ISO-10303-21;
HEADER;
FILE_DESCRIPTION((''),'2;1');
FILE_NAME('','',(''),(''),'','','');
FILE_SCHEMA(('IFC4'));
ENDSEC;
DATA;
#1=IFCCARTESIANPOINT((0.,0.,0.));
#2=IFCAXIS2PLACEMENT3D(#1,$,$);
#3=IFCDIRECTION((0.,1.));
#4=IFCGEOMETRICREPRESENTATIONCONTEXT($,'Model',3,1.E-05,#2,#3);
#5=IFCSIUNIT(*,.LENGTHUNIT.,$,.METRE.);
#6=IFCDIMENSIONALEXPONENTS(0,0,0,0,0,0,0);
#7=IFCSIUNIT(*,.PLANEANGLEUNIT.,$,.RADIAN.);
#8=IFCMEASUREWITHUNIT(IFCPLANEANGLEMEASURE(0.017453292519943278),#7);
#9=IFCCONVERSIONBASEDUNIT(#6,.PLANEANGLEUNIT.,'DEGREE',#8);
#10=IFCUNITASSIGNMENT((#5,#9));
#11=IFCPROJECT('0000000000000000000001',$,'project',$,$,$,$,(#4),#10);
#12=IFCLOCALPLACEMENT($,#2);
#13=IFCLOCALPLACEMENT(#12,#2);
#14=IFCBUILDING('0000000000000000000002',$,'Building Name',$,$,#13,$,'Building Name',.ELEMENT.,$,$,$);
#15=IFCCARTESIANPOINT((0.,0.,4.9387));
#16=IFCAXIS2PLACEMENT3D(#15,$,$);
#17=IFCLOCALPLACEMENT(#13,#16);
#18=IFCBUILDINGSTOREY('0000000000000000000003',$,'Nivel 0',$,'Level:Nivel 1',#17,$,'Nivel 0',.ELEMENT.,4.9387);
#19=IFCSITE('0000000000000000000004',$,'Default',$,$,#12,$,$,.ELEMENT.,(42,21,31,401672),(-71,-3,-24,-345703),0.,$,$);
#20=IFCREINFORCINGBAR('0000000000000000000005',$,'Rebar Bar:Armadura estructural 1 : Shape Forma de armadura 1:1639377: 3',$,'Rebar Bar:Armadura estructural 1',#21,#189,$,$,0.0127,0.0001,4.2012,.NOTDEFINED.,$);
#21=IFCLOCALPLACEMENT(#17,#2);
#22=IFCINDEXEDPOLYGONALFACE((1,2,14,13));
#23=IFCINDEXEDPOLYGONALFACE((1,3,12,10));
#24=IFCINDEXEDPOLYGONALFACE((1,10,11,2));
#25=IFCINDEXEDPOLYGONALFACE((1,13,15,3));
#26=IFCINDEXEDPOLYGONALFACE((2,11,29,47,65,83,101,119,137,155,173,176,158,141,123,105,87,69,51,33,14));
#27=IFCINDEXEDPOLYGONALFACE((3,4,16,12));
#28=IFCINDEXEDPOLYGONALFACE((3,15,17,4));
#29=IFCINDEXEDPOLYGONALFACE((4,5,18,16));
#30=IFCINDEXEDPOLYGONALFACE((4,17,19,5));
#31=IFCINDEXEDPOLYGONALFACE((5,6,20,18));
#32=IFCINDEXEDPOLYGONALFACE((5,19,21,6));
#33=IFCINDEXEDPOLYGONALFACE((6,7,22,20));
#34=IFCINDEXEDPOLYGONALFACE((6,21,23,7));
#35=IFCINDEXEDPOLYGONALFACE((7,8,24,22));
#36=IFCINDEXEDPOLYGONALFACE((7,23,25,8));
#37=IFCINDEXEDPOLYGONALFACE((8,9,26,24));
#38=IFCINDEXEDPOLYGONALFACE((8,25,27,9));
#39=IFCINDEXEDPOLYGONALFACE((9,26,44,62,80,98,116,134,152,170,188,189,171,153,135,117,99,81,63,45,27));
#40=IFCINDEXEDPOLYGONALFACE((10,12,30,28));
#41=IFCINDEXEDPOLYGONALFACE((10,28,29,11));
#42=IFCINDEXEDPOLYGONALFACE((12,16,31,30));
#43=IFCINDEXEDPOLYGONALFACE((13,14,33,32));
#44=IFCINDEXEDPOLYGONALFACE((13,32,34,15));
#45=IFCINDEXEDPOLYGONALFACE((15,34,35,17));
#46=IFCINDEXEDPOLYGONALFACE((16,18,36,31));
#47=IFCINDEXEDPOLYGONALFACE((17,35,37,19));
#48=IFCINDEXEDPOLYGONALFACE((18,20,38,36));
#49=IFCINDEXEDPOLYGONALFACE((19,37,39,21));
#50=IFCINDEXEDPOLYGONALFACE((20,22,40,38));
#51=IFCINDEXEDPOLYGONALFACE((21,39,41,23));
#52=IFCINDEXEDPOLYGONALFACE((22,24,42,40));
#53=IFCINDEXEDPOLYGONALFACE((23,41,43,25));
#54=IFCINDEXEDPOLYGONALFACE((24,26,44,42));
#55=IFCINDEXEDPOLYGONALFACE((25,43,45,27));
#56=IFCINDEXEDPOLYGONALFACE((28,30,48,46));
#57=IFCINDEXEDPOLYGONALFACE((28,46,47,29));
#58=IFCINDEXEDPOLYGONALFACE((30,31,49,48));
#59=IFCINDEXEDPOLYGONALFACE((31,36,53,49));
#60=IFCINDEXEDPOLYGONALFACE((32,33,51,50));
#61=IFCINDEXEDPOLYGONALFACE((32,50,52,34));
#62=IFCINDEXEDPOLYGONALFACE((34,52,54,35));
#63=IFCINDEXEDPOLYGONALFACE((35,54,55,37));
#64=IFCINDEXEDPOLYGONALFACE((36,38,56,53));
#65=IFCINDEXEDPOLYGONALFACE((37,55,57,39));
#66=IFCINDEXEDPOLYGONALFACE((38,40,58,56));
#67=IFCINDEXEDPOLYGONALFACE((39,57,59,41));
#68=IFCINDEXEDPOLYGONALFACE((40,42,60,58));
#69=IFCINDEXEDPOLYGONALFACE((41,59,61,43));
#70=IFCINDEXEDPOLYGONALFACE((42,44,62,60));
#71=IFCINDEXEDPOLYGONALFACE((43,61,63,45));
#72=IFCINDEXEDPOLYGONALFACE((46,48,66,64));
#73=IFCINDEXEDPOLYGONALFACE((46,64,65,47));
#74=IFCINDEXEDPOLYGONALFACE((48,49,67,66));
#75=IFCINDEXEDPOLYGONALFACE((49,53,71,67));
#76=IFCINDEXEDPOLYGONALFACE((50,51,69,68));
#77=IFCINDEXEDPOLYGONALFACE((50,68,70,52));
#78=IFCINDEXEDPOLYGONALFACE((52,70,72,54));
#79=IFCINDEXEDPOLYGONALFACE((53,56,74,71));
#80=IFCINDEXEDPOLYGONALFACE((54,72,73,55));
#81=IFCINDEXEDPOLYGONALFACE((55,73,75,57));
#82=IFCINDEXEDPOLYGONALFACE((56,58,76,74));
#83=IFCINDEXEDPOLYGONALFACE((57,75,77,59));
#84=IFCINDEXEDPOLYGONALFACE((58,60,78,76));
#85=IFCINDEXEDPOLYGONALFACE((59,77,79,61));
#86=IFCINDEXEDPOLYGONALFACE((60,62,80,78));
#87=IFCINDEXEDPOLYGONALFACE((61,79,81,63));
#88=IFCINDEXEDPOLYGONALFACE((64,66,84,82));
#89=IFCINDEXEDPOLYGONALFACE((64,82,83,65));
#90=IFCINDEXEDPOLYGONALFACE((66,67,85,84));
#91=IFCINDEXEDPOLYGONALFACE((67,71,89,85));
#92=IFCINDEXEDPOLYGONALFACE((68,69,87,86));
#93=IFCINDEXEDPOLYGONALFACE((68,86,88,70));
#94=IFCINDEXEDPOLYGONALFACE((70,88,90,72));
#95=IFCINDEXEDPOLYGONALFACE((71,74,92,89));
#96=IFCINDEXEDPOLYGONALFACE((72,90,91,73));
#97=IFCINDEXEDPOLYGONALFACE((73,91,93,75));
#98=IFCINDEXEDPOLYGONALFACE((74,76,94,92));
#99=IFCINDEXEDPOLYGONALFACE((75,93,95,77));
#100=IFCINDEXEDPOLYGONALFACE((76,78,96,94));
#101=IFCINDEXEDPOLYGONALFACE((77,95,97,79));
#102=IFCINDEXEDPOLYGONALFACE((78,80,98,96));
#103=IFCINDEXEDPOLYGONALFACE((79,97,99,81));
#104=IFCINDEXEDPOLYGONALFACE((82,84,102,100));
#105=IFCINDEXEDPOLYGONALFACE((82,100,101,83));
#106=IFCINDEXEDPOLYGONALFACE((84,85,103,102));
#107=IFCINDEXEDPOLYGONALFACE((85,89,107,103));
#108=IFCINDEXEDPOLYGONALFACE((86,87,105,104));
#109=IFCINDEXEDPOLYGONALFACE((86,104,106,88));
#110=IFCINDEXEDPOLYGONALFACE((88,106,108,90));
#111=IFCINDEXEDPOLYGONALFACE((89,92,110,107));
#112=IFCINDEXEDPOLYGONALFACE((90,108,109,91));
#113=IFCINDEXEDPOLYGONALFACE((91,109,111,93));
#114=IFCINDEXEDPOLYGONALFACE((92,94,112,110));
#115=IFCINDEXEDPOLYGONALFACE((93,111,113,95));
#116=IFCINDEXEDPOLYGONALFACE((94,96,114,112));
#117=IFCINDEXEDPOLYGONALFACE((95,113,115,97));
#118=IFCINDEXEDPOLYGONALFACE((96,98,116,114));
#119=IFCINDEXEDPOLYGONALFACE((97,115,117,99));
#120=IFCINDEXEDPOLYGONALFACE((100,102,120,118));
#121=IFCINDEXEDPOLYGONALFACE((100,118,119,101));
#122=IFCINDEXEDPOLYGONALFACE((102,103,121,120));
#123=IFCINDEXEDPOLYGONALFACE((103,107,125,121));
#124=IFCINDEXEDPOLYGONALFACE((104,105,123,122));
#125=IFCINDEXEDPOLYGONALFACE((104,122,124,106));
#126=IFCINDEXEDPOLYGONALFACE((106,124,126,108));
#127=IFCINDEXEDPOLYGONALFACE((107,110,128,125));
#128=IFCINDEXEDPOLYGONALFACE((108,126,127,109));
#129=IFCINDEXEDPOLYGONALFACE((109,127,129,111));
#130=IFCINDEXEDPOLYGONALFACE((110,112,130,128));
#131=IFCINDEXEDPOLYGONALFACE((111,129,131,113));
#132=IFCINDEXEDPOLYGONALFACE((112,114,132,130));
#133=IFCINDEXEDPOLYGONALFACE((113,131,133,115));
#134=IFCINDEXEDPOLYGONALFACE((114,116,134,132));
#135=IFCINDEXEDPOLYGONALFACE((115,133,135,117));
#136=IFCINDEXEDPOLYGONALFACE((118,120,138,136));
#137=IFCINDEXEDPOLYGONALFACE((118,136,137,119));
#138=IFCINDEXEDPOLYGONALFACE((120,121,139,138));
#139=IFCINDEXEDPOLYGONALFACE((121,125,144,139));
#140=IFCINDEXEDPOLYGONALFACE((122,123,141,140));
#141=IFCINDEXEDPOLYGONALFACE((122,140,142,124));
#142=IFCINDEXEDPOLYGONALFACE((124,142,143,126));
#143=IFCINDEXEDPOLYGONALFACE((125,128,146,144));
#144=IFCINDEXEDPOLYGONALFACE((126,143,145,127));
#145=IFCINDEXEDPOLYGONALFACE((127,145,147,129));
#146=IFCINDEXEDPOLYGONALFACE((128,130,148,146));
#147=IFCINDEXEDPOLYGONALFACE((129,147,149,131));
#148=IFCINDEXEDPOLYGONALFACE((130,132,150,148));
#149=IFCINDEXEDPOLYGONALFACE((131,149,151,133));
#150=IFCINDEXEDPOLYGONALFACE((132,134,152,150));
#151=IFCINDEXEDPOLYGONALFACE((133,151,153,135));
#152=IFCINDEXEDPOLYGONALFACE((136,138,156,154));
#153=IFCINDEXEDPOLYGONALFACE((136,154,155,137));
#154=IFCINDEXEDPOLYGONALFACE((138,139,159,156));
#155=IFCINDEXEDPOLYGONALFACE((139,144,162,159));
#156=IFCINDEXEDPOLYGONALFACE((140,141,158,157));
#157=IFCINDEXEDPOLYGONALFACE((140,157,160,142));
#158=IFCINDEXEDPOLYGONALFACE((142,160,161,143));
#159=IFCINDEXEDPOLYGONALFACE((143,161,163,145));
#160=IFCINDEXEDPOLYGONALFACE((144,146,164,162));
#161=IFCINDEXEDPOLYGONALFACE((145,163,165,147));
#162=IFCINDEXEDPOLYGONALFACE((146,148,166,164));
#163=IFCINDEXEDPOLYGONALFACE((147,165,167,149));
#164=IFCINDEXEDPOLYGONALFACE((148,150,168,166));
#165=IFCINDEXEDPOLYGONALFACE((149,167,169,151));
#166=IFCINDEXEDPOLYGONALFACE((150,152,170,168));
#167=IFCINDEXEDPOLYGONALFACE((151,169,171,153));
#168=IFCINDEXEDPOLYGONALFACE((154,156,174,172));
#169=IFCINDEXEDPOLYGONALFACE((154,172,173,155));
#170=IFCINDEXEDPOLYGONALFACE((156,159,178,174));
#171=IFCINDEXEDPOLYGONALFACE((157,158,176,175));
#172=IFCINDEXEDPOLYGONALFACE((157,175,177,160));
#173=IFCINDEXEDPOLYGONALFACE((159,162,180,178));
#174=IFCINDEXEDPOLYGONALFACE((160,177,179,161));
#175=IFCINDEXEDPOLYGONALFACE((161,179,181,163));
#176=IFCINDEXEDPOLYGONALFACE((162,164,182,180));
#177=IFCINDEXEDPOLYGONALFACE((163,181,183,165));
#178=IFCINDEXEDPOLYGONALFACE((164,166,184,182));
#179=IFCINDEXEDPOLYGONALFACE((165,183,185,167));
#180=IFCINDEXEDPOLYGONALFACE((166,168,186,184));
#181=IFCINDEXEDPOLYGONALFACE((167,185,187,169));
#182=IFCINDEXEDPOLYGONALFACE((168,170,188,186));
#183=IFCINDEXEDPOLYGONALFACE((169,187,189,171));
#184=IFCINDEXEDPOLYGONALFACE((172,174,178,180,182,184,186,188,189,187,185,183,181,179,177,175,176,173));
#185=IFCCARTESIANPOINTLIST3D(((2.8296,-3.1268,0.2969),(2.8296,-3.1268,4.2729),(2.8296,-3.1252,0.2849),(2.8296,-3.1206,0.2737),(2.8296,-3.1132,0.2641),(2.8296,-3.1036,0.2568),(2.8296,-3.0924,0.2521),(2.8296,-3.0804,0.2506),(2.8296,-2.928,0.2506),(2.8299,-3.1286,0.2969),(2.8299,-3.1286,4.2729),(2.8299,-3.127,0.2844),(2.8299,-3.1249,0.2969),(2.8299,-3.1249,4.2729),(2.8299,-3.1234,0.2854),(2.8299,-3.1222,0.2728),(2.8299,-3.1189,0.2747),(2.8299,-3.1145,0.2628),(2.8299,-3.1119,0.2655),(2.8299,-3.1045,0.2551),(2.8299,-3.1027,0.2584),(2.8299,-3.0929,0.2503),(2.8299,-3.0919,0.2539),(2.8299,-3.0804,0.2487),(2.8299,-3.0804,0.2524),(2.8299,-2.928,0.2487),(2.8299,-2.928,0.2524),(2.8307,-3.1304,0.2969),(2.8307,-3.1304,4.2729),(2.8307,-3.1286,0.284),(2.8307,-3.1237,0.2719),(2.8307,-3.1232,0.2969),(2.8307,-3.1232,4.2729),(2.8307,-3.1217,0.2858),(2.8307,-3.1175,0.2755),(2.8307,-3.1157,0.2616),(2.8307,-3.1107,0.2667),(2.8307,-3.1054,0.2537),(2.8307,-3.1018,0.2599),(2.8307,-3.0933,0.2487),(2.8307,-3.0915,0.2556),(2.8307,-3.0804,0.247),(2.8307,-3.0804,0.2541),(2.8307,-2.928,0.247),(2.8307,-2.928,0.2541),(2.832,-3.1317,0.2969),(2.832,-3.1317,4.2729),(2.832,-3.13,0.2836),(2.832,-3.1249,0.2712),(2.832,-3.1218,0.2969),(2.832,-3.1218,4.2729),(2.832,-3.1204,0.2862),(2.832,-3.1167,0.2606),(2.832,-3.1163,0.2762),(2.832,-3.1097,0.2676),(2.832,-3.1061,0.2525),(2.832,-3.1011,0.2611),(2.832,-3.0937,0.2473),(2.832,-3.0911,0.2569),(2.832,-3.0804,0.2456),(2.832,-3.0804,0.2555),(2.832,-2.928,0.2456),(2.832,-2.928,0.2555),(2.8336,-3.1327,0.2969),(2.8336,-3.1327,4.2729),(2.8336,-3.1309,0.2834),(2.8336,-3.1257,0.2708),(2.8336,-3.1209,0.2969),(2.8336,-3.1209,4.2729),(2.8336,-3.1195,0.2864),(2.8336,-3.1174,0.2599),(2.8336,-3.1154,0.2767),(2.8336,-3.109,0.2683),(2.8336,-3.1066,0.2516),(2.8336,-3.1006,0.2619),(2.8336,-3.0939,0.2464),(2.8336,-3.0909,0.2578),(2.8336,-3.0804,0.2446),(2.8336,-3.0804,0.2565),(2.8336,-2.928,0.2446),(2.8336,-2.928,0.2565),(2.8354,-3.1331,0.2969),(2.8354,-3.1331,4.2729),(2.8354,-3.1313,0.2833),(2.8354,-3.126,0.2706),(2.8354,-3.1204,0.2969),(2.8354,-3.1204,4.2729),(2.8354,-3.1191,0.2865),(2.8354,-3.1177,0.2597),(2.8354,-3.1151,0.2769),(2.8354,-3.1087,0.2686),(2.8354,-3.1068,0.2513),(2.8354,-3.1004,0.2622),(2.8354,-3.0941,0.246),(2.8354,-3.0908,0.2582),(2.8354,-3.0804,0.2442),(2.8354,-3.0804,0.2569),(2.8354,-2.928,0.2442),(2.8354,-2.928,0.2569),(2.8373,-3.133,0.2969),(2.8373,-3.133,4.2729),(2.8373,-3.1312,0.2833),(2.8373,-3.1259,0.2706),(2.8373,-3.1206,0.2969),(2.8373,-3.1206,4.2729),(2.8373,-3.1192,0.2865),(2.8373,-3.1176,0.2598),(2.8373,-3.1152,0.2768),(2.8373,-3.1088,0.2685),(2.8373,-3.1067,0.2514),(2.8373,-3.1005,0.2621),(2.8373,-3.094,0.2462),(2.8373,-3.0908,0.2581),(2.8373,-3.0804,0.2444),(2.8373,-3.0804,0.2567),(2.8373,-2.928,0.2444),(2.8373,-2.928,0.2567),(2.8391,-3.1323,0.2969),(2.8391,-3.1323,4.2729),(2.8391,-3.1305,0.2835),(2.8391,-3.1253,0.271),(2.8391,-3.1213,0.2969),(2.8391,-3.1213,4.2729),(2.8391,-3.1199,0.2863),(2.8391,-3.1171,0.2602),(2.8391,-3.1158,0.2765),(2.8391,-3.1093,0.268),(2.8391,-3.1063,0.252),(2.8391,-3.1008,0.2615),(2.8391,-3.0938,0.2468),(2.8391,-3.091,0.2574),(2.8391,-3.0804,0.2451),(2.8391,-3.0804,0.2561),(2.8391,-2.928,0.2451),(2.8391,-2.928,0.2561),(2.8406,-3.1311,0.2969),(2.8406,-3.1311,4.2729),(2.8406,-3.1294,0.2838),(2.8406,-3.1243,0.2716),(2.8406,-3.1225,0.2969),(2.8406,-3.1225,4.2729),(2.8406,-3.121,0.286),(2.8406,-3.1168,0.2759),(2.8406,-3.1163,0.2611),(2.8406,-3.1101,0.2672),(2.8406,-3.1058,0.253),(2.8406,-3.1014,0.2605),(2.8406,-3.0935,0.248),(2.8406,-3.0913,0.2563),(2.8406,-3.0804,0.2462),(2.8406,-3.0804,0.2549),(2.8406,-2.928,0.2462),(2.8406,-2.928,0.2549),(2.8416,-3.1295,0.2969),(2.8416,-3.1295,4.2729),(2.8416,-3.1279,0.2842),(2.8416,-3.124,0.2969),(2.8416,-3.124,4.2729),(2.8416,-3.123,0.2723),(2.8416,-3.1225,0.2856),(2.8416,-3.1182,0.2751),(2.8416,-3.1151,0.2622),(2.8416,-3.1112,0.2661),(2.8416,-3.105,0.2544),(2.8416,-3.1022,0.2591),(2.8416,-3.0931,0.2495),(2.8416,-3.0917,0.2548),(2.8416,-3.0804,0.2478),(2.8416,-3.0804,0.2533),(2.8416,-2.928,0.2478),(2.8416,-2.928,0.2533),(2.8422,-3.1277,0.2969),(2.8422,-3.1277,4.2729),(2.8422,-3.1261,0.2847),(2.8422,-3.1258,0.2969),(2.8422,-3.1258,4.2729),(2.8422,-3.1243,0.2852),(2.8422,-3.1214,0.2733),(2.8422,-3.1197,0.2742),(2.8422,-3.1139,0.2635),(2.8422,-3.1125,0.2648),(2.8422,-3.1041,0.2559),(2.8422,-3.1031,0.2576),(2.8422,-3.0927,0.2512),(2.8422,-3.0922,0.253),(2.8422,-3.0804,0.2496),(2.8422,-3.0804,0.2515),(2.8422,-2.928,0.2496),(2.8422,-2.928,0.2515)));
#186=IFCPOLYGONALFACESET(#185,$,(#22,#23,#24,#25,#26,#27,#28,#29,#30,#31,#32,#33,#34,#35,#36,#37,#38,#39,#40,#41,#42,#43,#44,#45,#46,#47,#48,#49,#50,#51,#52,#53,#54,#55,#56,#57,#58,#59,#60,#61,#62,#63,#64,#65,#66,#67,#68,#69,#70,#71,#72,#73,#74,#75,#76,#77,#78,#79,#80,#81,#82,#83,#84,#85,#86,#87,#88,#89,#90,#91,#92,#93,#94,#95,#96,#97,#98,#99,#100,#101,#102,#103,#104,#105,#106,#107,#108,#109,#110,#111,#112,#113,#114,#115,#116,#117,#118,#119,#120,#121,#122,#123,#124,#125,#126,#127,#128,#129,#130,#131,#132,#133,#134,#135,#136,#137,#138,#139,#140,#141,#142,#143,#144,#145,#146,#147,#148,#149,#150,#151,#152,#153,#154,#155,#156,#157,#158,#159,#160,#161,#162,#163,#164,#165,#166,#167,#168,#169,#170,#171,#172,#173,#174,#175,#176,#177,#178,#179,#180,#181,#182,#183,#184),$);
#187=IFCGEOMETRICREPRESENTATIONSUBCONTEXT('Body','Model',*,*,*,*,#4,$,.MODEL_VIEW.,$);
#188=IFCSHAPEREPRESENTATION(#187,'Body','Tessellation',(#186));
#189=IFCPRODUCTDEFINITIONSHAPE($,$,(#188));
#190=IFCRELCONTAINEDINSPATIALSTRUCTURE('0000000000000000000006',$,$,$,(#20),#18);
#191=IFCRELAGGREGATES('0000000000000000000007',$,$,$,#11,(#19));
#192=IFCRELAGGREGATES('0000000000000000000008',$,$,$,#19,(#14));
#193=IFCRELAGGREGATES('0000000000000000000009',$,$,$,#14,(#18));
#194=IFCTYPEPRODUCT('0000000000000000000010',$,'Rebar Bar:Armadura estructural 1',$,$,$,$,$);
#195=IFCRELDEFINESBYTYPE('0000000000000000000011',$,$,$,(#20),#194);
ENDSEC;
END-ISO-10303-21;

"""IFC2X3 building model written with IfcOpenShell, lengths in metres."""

from ifc_helpers import new_model, entity, si_unit, converted_unit, direction, frame, origin, place, context, subcontext, project, spatial, type_object, element, save


model = new_model("IFC2X3")

# Units and contexts
model_context = context("Model", 3, precision=1e-05, world=origin(), true_north=direction((0.0, 1.0)))
body_context = subcontext(model_context, "Body", "Model", "MODEL_VIEW")
ifc_project = project(units=[si_unit("LENGTHUNIT", "METRE"), converted_unit("PLANEANGLEUNIT", "DEGREE", entity("IfcPlaneAngleMeasure", 0.017453292519943278), si_unit("PLANEANGLEUNIT", "RADIAN"), dimensions=[0, 0, 0, 0, 0, 0, 0])], contexts=[model_context])

# Site, building, storey
site_placement = place(None, origin())
site = spatial("IfcSite", under=ifc_project, at=site_placement, Name="Default", CompositionType="ELEMENT", RefLatitude=(42, 21, 31, 401672), RefLongitude=(-71, -3, -24, -345703), RefElevation=0.0)
building_placement = place(site_placement, origin())
building = spatial("IfcBuilding", under=site, at=building_placement, Name="Building Name", LongName="Building Name", CompositionType="ELEMENT")
storey_placement = place(building_placement, frame((0.0, 0.0, 4.9387)))
storey = spatial("IfcBuildingStorey", under=building, at=storey_placement, Name="Nivel 0", ObjectType="Level:Nivel 1", LongName="Nivel 0", CompositionType="ELEMENT", Elevation=4.9387)

# Reinforcing bar
type_product = type_object("IfcTypeProduct", Name="Rebar Bar:Armadura estructural 1")
reinforcing_bar_1_placement = place(storey_placement, origin())
element("IfcReinforcingBar", 1, at=reinforcing_bar_1_placement, inside=storey, type_object=type_product, Name="Rebar Bar:Armadura estructural 1 : Shape Forma de armadura 1:1639377: 3", ObjectType="Rebar Bar:Armadura estructural 1", BarLength=4.2012, BarRole="NOTDEFINED", CrossSectionArea=0.0001, NominalDiameter=0.0127, context=body_context, shape_type="AdvancedSweptSolid", body=[
    entity("IfcSweptDiskSolid", entity("IfcCompositeCurve", [entity("IfcCompositeCurveSegment", "CONTINUOUS", True, entity("IfcPolyline", [entity("IfcCartesianPoint", [2.8359, -2.928, 0.2506]), entity("IfcCartesianPoint", [2.8359, -3.0804, 0.2506])])), entity("IfcCompositeCurveSegment", "CONTINUOUS", True, entity("IfcTrimmedCurve", entity("IfcCircle", entity("IfcAxis2Placement3D", entity("IfcCartesianPoint", [2.8359, -3.0804, 0.2969]), entity("IfcDirection", [-1.0, 0.0, 0.0]), entity("IfcDirection", [0.0, -1.0, 0.0])), 0.0464), [entity("IfcParameterValue", 270.0)], [entity("IfcParameterValue", 360.0)], True, "PARAMETER")), entity("IfcCompositeCurveSegment", "CONTINUOUS", True, entity("IfcPolyline", [entity("IfcCartesianPoint", [2.8359, -3.1268, 0.2969]), entity("IfcCartesianPoint", [2.8359, -3.1268, 4.2729])]))], False), 0.0063, None, 0.0, 92.0),
])

save(model, "model.ifc")
